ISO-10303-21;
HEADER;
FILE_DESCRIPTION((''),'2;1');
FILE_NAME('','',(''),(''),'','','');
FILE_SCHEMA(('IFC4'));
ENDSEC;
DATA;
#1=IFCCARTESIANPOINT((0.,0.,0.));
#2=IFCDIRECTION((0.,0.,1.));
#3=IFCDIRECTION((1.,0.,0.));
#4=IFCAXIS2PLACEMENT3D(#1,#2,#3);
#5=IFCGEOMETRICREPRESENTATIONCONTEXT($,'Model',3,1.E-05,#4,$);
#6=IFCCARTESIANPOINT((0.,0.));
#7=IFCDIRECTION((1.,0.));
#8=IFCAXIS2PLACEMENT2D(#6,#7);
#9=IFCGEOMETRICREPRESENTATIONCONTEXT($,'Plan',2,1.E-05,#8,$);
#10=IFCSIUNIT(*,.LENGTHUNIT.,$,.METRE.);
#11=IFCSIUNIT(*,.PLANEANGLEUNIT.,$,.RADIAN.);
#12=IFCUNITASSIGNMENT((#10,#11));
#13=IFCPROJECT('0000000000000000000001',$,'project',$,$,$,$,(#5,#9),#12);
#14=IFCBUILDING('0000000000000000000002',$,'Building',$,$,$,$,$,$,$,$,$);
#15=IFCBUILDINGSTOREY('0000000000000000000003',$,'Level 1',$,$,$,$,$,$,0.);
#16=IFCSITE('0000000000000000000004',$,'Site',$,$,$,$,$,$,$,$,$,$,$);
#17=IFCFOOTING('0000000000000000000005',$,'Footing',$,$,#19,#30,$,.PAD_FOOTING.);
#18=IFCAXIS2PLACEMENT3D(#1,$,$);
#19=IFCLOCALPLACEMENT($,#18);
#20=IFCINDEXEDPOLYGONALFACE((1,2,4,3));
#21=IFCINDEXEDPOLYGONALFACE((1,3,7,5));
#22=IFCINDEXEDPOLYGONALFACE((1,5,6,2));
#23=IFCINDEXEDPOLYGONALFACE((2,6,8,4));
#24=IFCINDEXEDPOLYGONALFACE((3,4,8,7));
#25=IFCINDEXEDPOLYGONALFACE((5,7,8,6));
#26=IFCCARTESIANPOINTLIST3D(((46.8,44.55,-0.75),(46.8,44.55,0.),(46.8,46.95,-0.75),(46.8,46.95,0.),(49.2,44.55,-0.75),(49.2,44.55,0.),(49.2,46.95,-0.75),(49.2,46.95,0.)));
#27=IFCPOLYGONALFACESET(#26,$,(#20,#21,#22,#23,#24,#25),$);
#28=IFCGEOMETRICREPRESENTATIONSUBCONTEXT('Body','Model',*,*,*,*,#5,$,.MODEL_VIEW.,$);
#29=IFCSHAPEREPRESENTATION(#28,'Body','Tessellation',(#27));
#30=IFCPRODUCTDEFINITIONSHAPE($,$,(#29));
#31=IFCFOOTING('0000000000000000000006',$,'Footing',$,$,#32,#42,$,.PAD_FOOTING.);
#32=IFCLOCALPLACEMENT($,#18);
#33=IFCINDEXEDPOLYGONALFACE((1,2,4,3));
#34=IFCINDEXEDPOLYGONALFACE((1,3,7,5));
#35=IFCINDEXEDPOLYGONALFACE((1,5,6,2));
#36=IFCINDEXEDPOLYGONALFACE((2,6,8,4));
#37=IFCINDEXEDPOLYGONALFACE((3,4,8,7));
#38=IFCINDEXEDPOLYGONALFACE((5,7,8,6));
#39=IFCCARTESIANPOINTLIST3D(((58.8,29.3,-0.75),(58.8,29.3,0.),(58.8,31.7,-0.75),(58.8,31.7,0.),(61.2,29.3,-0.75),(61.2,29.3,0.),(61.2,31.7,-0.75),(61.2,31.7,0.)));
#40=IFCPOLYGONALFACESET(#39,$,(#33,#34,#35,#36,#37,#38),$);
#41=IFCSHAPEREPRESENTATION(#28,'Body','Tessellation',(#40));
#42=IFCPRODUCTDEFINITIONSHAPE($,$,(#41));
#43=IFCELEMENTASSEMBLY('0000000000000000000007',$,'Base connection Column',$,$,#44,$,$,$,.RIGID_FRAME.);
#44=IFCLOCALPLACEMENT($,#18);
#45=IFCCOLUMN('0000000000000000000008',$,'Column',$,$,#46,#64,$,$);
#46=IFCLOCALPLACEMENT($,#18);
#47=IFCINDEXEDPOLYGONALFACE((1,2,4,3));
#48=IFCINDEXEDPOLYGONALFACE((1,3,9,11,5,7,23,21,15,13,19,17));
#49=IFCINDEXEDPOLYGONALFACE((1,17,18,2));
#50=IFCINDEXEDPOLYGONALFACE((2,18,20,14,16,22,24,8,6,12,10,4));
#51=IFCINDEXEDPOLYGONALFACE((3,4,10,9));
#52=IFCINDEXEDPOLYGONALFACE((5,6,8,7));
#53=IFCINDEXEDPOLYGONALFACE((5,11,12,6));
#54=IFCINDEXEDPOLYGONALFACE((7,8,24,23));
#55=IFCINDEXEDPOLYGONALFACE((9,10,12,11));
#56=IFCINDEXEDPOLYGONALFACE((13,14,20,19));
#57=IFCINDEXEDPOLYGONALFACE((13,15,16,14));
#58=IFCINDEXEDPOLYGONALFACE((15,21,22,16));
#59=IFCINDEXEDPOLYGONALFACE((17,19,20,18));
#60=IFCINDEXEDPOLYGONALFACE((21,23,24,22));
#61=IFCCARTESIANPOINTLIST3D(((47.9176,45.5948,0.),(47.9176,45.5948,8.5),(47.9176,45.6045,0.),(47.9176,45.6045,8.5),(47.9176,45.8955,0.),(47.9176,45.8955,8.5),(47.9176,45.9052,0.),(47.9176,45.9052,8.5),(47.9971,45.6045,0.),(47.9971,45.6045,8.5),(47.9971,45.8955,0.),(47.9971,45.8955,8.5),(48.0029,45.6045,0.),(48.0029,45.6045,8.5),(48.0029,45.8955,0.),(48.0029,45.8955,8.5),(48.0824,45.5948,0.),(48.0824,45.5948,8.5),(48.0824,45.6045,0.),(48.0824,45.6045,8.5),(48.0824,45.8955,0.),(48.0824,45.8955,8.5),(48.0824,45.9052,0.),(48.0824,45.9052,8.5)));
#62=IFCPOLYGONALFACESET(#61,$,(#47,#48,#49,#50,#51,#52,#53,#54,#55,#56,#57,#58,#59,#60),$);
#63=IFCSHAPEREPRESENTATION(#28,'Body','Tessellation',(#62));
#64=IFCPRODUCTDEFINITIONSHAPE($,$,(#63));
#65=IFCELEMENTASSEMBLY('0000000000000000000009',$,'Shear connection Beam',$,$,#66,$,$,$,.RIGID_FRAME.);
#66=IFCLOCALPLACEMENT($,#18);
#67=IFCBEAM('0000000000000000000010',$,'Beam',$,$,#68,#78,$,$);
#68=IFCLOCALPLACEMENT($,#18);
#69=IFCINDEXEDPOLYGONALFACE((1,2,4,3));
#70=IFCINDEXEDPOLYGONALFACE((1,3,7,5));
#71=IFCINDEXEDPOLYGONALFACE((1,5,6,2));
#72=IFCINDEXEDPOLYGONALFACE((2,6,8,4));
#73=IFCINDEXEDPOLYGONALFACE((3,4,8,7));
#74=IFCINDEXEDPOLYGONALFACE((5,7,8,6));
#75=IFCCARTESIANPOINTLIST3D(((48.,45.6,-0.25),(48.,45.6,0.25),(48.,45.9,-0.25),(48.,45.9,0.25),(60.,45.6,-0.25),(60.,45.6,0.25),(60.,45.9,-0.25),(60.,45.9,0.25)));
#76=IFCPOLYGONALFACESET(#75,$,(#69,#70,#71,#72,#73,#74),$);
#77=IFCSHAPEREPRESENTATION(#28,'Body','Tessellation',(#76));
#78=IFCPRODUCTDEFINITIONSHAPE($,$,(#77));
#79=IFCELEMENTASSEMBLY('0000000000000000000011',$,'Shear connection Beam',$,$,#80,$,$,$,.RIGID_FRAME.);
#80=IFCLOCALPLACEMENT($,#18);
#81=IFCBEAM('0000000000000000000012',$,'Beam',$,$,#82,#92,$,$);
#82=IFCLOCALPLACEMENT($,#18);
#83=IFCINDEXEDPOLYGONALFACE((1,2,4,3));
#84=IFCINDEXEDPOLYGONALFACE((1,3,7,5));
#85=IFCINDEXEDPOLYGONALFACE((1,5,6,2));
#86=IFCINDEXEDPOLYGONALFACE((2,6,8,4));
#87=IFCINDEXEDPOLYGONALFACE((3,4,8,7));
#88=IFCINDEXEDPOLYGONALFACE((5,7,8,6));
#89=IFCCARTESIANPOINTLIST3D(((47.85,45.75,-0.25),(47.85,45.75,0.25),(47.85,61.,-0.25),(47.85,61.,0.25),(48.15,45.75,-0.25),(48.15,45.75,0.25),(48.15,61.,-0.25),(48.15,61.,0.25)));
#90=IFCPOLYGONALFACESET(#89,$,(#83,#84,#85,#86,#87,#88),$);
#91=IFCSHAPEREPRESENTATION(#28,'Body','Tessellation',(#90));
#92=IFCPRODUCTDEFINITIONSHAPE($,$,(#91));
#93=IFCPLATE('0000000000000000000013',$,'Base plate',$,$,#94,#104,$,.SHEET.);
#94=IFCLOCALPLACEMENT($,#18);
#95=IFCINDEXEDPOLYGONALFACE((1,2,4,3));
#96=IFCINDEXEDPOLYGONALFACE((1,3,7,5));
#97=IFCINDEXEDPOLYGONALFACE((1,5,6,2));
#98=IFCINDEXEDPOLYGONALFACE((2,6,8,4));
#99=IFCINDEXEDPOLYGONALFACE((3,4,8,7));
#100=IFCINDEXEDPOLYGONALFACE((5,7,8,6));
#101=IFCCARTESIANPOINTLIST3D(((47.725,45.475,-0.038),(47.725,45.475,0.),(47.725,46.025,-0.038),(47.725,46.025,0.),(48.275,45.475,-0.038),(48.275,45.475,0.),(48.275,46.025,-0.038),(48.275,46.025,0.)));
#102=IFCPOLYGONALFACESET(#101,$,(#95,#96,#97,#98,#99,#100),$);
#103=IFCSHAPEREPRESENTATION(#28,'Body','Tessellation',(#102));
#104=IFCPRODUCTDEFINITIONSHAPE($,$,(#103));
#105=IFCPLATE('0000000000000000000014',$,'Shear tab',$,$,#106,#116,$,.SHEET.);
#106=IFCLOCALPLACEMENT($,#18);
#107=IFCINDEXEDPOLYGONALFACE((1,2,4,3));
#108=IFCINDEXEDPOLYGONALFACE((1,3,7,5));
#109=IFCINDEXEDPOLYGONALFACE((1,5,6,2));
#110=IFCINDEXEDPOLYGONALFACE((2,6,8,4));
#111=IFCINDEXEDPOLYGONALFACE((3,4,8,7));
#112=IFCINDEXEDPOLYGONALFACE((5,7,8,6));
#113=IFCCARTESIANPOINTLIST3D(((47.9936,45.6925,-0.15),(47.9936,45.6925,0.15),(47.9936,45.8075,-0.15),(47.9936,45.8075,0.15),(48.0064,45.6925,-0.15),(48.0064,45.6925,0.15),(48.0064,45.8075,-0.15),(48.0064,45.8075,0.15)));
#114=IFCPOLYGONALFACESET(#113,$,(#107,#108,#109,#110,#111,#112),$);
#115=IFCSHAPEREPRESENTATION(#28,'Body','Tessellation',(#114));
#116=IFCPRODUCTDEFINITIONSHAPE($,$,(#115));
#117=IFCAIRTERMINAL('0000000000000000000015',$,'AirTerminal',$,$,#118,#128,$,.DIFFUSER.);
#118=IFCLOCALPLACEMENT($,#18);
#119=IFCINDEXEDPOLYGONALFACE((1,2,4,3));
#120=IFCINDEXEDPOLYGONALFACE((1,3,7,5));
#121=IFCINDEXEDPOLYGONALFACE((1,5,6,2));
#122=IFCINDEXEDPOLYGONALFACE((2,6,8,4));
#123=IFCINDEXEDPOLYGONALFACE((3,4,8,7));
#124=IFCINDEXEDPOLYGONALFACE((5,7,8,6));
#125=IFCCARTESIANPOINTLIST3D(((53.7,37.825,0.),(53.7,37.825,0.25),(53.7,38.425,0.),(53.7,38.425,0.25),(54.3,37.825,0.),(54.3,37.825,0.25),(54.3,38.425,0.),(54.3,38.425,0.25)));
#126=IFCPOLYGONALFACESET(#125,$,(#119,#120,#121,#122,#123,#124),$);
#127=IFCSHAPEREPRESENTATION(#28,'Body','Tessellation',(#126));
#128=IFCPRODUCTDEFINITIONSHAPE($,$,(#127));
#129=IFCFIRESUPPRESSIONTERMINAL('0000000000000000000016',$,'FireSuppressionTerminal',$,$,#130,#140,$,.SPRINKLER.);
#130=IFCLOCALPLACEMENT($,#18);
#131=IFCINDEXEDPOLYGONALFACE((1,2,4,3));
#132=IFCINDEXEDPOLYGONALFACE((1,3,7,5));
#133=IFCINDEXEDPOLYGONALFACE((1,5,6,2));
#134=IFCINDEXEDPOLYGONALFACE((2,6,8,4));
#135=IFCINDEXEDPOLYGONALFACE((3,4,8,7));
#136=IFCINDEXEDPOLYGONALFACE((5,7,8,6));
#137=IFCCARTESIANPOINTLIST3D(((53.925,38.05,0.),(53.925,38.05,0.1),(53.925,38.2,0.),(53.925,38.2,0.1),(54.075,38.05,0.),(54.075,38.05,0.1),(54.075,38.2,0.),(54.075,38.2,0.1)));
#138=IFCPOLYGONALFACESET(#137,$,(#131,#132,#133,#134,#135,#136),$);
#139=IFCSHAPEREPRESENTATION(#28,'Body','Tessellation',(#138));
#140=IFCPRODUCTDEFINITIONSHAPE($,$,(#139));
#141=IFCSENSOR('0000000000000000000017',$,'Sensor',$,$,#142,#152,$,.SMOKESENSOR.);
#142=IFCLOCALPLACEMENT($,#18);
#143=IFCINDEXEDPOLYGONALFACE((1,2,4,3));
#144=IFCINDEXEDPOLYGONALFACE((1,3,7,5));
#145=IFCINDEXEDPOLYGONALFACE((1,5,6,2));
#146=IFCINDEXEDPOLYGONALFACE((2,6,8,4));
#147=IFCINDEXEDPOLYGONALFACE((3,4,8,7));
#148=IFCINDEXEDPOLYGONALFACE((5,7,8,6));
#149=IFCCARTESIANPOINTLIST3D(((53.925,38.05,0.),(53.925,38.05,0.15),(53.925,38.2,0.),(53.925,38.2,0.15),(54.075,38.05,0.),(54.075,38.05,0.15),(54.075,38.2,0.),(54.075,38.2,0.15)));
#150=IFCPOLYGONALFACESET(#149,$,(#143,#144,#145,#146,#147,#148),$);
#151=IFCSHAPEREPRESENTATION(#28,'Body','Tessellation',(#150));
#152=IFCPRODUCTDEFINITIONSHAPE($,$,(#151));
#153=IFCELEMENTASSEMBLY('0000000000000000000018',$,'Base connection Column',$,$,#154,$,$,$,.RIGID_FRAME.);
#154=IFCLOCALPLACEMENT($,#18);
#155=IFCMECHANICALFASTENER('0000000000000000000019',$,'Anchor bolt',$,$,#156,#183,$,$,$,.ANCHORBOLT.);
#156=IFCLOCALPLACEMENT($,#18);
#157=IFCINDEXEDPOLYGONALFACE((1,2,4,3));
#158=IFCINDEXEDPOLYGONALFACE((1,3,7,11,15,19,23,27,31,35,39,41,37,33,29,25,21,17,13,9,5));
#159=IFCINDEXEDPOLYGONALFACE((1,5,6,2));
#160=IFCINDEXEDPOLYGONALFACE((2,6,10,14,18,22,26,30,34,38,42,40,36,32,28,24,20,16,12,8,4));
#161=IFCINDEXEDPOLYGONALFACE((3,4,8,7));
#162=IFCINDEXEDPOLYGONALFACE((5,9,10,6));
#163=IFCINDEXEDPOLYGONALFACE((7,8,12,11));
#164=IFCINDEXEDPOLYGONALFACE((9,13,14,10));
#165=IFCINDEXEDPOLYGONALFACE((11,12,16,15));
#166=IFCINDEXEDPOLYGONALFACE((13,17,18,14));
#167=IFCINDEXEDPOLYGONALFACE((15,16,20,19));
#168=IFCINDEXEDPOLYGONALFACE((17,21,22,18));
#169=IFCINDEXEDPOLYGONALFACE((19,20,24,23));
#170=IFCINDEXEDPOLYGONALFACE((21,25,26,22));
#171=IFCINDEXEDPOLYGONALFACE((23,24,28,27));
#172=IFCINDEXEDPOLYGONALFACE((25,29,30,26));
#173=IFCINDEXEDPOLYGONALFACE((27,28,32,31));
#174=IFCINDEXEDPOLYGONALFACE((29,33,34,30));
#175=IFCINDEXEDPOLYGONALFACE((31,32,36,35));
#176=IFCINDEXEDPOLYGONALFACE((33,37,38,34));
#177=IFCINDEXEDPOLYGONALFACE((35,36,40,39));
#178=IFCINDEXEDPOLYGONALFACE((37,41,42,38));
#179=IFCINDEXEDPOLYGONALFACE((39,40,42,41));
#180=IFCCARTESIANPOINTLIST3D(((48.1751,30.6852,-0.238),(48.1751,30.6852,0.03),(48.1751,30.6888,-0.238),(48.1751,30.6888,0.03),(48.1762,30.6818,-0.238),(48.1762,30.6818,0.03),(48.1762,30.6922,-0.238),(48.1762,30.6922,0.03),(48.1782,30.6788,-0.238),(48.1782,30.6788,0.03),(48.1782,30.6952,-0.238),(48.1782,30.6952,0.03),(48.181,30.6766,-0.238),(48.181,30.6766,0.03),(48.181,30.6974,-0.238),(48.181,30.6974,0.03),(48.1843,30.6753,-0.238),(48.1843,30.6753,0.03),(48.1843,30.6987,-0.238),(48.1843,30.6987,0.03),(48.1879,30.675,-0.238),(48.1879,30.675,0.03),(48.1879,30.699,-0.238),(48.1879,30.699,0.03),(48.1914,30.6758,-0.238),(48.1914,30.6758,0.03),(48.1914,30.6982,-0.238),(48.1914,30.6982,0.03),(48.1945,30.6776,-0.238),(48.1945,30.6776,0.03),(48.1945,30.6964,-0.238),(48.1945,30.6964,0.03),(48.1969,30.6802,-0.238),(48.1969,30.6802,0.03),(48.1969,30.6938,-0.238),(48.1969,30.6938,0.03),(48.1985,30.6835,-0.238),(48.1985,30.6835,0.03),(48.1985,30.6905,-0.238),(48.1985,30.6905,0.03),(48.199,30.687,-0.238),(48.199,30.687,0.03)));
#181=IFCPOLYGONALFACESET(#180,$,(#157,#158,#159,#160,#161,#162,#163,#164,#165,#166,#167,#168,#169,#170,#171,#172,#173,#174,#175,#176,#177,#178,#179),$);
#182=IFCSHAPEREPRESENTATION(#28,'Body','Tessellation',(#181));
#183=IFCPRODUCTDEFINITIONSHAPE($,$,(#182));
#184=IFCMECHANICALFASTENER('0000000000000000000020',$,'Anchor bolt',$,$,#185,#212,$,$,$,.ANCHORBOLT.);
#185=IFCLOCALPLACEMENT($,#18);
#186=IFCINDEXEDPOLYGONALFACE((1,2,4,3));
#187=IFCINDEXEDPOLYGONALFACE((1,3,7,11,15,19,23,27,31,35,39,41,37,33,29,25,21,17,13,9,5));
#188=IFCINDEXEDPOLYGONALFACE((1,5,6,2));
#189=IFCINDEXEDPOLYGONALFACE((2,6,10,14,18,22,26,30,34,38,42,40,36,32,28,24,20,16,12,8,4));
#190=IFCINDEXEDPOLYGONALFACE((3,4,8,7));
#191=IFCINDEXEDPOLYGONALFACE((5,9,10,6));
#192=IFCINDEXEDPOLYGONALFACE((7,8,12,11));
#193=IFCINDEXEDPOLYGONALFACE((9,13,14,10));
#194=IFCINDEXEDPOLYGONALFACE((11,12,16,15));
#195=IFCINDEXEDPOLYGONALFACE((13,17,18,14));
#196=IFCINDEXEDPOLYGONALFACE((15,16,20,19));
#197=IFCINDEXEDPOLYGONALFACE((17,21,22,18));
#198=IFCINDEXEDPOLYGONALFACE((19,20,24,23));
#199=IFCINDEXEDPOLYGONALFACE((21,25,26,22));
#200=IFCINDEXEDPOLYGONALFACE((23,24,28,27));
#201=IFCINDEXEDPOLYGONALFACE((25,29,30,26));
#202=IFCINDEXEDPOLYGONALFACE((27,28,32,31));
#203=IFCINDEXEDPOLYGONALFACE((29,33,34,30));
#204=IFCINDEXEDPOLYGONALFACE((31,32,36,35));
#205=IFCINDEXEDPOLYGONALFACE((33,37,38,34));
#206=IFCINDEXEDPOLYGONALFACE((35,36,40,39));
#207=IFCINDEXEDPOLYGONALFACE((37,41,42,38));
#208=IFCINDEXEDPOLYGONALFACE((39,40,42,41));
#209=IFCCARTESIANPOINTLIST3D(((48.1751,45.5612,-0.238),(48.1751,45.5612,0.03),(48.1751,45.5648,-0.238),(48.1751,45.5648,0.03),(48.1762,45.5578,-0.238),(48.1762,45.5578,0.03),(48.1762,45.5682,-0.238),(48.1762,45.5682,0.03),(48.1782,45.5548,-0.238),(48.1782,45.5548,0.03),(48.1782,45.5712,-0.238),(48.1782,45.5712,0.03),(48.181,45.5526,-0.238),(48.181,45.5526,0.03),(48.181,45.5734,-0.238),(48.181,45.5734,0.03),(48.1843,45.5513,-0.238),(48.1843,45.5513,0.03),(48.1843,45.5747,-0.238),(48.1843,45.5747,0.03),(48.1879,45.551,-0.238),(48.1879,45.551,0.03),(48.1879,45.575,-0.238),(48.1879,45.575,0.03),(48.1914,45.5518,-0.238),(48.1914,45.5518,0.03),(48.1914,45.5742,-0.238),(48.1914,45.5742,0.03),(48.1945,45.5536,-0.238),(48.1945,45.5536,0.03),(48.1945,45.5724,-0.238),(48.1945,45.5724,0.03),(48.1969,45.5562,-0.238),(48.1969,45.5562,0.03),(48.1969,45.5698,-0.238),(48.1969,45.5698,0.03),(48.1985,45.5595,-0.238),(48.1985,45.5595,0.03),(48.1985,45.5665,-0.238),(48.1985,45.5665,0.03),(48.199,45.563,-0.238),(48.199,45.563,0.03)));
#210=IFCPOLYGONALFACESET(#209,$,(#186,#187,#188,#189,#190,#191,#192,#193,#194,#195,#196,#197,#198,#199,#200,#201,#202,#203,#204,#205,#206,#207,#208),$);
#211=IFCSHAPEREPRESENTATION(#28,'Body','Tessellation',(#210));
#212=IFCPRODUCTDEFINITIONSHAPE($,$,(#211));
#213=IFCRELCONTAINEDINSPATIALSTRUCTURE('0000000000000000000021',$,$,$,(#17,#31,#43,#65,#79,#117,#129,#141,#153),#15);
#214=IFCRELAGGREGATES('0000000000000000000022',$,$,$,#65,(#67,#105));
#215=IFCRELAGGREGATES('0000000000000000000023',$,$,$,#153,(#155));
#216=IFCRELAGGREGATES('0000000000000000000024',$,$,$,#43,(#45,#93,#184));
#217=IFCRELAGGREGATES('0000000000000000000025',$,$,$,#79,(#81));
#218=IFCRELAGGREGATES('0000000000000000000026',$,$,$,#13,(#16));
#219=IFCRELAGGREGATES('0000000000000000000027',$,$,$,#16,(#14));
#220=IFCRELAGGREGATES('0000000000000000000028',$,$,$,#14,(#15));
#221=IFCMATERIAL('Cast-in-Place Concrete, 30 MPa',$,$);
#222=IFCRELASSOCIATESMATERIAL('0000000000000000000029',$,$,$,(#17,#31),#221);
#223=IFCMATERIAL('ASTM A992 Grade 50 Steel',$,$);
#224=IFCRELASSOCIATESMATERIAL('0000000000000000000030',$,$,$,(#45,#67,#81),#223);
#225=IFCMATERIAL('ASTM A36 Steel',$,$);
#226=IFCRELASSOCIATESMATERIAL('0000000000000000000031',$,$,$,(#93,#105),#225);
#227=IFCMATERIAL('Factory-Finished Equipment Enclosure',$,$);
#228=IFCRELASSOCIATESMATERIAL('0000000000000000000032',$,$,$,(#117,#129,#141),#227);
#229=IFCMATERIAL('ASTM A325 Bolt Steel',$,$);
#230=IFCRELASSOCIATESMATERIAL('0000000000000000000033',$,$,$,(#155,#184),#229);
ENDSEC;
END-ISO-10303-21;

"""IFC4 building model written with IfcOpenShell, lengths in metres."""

from ifc_helpers import new_model, si_unit, frame, origin_with_axes, origin_2d, origin_2d_with_axis, place, context, subcontext, project, spatial, rectangle, circle, i_section, extrude, material, element, aggregate, save


model = new_model("IFC4")

# Units and contexts
model_context = context("Model", 3, precision=1e-05, world=origin_with_axes())
plan_context = context("Plan", 2, precision=1e-05, world=origin_2d_with_axis())
body_context = subcontext(model_context, "Body", "Model", "MODEL_VIEW")
ifc_project = project(units=[si_unit("LENGTHUNIT", "METRE"), si_unit("PLANEANGLEUNIT", "RADIAN")], contexts=[model_context, plan_context])

# Site, building, storey
site = spatial("IfcSite", under=ifc_project, Name="Site")
building = spatial("IfcBuilding", under=site, Name="Building")
storey = spatial("IfcBuildingStorey", under=building, Name="Level 1", Elevation=0.0)

# Footings
ifc_material_1 = material(Name="Cast-in-Place Concrete, 30 MPa")
for number, where, z_axis, x_axis, name in (
    (1, (48.0, 45.75, -0.75), (0.0, 0.0, 1.0), (1.0, 0.0, 0.0), "Footing"),
    (2, (60.0, 30.5, -0.75), (0.0, 0.0, 1.0), (1.0, 0.0, 0.0), "Footing"),
):
    element("IfcFooting", number, at=place(None, frame(where, z_axis=z_axis, x_axis=x_axis)), inside=storey, material=ifc_material_1, Name=name, PredefinedType="PAD_FOOTING", context=body_context, shape_type="SweptSolid", body=[
        extrude(rectangle(XDim=2.4, YDim=2.4, at=origin_2d_with_axis()), origin_with_axes(), (0.0, 0.0, 1.0), 0.75),
    ])

# Element assembly, column
assembly_1 = element("IfcElementAssembly", 3, inside=storey, Name="Base connection Column", PredefinedType="RIGID_FRAME")
ifc_material_2 = material(Name="ASTM A992 Grade 50 Steel")
column_placement = place(None, frame((48.0, 45.75, 0.0), z_axis=(0.0, 0.0, 1.0), x_axis=(1.0, 0.0, 0.0)))
column = element("IfcColumn", 4, at=column_placement, material=ifc_material_2, Name="Column", context=body_context, shape_type="SweptSolid", body=[
    extrude(i_section(OverallWidth=0.1648, OverallDepth=0.3104, WebThickness=0.0058, FlangeThickness=0.0097, at=origin_2d_with_axis()), origin_with_axes(), (0.0, 0.0, 1.0), 8.5),
])

# Element assemblies, beams
assembly_2 = element("IfcElementAssembly", 5, inside=storey, Name="Shear connection Beam", PredefinedType="RIGID_FRAME")
beam_1_placement = place(None, frame((48.0, 45.75, 0.0), z_axis=(1.0, 0.0, 0.0), x_axis=(0.0, 1.0, 0.0)))
beam_1 = element("IfcBeam", 6, at=beam_1_placement, material=ifc_material_2, Name="Beam", context=body_context, shape_type="SweptSolid", body=[
    extrude(rectangle(XDim=0.3, YDim=0.5, at=origin_2d_with_axis()), origin_with_axes(), (0.0, 0.0, 1.0), 12.0),
])
assembly_3 = element("IfcElementAssembly", 7, inside=storey, Name="Shear connection Beam", PredefinedType="RIGID_FRAME")
beam_2_placement = place(None, frame((48.0, 45.75, 0.0), z_axis=(0.0, 1.0, 0.0), x_axis=(-1.0, 0.0, 0.0)))
beam_2 = element("IfcBeam", 8, at=beam_2_placement, material=ifc_material_2, Name="Beam", context=body_context, shape_type="SweptSolid", body=[
    extrude(rectangle(XDim=0.3, YDim=0.5, at=origin_2d_with_axis()), origin_with_axes(), (0.0, 0.0, 1.0), 15.25),
])

# Plates
ifc_material_3 = material(Name="ASTM A36 Steel")
plate_1_placement = place(None, frame((48.0, 45.75, -0.038), z_axis=(0.0, 0.0, 1.0), x_axis=(1.0, 0.0, 0.0)))
plate_1 = element("IfcPlate", 9, at=plate_1_placement, material=ifc_material_3, Name="Base plate", PredefinedType="SHEET", context=body_context, shape_type="SweptSolid", body=[
    extrude(rectangle(XDim=0.55, YDim=0.55, at=origin_2d_with_axis()), origin_with_axes(), (0.0, 0.0, 1.0), 0.038),
])
plate_2_placement = place(None, frame((48.0, 45.75, -0.15), z_axis=(0.0, 0.0, 1.0), x_axis=(1.0, 0.0, 0.0)))
plate_2 = element("IfcPlate", 10, at=plate_2_placement, material=ifc_material_3, Name="Shear tab", PredefinedType="SHEET", context=body_context, shape_type="SweptSolid", body=[
    extrude(rectangle(XDim=0.0127, YDim=0.115, at=origin_2d_with_axis()), origin_with_axes(), (0.0, 0.0, 1.0), 0.3),
])
aggregate(assembly_2, [beam_1, plate_2])

# Air terminal
ifc_material_4 = material(Name="Factory-Finished Equipment Enclosure")
air_terminal_placement = place(None, frame((54.0, 38.125, 0.0), z_axis=(0.0, 0.0, 1.0), x_axis=(1.0, 0.0, 0.0)))
element("IfcAirTerminal", 11, at=air_terminal_placement, inside=storey, material=ifc_material_4, Name="AirTerminal", PredefinedType="DIFFUSER", context=body_context, shape_type="SweptSolid", body=[
    extrude(rectangle(XDim=0.6, YDim=0.6, at=origin_2d_with_axis()), origin_with_axes(), (0.0, 0.0, 1.0), 0.25),
])

# Fire suppression terminal
fire_suppression_terminal_placement = place(None, frame((54.0, 38.125, 0.0), z_axis=(0.0, 0.0, 1.0), x_axis=(1.0, 0.0, 0.0)))
element("IfcFireSuppressionTerminal", 12, at=fire_suppression_terminal_placement, inside=storey, material=ifc_material_4, Name="FireSuppressionTerminal", PredefinedType="SPRINKLER", context=body_context, shape_type="SweptSolid", body=[
    extrude(rectangle(XDim=0.15, YDim=0.15, at=origin_2d_with_axis()), origin_with_axes(), (0.0, 0.0, 1.0), 0.1),
])

# Sensor
sensor_placement = place(None, frame((54.0, 38.125, 0.0), z_axis=(0.0, 0.0, 1.0), x_axis=(1.0, 0.0, 0.0)))
element("IfcSensor", 13, at=sensor_placement, inside=storey, material=ifc_material_4, Name="Sensor", PredefinedType="SMOKESENSOR", context=body_context, shape_type="SweptSolid", body=[
    extrude(rectangle(XDim=0.15, YDim=0.15, at=origin_2d_with_axis()), origin_with_axes(), (0.0, 0.0, 1.0), 0.15),
])

# Element assembly, mechanical fastener
assembly_4 = element("IfcElementAssembly", 14, inside=storey, Name="Base connection Column", PredefinedType="RIGID_FRAME")
ifc_material_5 = material(Name="ASTM A325 Bolt Steel")
mechanical_fastener_1_placement = place(None, frame((48.187, 30.687, -0.238), z_axis=(0.0, 0.0, 1.0), x_axis=(1.0, 0.0, 0.0)))
mechanical_fastener_1 = element("IfcMechanicalFastener", 15, at=mechanical_fastener_1_placement, material=ifc_material_5, Name="Anchor bolt", PredefinedType="ANCHORBOLT", context=body_context, shape_type="SweptSolid", body=[
    extrude(circle(Radius=0.012, at=origin_2d()), origin_with_axes(), (0.0, 0.0, 1.0), 0.268),
])
aggregate(assembly_4, [mechanical_fastener_1])

# Mechanical fastener
mechanical_fastener_2_placement = place(None, frame((48.187, 45.563, -0.238), z_axis=(0.0, 0.0, 1.0), x_axis=(1.0, 0.0, 0.0)))
mechanical_fastener_2 = element("IfcMechanicalFastener", 16, at=mechanical_fastener_2_placement, material=ifc_material_5, Name="Anchor bolt", PredefinedType="ANCHORBOLT", context=body_context, shape_type="SweptSolid", body=[
    extrude(circle(Radius=0.012, at=origin_2d()), origin_with_axes(), (0.0, 0.0, 1.0), 0.268),
])
aggregate(assembly_1, [column, plate_1, mechanical_fastener_2])

aggregate(assembly_3, [beam_2])

save(model, "model.ifc")
